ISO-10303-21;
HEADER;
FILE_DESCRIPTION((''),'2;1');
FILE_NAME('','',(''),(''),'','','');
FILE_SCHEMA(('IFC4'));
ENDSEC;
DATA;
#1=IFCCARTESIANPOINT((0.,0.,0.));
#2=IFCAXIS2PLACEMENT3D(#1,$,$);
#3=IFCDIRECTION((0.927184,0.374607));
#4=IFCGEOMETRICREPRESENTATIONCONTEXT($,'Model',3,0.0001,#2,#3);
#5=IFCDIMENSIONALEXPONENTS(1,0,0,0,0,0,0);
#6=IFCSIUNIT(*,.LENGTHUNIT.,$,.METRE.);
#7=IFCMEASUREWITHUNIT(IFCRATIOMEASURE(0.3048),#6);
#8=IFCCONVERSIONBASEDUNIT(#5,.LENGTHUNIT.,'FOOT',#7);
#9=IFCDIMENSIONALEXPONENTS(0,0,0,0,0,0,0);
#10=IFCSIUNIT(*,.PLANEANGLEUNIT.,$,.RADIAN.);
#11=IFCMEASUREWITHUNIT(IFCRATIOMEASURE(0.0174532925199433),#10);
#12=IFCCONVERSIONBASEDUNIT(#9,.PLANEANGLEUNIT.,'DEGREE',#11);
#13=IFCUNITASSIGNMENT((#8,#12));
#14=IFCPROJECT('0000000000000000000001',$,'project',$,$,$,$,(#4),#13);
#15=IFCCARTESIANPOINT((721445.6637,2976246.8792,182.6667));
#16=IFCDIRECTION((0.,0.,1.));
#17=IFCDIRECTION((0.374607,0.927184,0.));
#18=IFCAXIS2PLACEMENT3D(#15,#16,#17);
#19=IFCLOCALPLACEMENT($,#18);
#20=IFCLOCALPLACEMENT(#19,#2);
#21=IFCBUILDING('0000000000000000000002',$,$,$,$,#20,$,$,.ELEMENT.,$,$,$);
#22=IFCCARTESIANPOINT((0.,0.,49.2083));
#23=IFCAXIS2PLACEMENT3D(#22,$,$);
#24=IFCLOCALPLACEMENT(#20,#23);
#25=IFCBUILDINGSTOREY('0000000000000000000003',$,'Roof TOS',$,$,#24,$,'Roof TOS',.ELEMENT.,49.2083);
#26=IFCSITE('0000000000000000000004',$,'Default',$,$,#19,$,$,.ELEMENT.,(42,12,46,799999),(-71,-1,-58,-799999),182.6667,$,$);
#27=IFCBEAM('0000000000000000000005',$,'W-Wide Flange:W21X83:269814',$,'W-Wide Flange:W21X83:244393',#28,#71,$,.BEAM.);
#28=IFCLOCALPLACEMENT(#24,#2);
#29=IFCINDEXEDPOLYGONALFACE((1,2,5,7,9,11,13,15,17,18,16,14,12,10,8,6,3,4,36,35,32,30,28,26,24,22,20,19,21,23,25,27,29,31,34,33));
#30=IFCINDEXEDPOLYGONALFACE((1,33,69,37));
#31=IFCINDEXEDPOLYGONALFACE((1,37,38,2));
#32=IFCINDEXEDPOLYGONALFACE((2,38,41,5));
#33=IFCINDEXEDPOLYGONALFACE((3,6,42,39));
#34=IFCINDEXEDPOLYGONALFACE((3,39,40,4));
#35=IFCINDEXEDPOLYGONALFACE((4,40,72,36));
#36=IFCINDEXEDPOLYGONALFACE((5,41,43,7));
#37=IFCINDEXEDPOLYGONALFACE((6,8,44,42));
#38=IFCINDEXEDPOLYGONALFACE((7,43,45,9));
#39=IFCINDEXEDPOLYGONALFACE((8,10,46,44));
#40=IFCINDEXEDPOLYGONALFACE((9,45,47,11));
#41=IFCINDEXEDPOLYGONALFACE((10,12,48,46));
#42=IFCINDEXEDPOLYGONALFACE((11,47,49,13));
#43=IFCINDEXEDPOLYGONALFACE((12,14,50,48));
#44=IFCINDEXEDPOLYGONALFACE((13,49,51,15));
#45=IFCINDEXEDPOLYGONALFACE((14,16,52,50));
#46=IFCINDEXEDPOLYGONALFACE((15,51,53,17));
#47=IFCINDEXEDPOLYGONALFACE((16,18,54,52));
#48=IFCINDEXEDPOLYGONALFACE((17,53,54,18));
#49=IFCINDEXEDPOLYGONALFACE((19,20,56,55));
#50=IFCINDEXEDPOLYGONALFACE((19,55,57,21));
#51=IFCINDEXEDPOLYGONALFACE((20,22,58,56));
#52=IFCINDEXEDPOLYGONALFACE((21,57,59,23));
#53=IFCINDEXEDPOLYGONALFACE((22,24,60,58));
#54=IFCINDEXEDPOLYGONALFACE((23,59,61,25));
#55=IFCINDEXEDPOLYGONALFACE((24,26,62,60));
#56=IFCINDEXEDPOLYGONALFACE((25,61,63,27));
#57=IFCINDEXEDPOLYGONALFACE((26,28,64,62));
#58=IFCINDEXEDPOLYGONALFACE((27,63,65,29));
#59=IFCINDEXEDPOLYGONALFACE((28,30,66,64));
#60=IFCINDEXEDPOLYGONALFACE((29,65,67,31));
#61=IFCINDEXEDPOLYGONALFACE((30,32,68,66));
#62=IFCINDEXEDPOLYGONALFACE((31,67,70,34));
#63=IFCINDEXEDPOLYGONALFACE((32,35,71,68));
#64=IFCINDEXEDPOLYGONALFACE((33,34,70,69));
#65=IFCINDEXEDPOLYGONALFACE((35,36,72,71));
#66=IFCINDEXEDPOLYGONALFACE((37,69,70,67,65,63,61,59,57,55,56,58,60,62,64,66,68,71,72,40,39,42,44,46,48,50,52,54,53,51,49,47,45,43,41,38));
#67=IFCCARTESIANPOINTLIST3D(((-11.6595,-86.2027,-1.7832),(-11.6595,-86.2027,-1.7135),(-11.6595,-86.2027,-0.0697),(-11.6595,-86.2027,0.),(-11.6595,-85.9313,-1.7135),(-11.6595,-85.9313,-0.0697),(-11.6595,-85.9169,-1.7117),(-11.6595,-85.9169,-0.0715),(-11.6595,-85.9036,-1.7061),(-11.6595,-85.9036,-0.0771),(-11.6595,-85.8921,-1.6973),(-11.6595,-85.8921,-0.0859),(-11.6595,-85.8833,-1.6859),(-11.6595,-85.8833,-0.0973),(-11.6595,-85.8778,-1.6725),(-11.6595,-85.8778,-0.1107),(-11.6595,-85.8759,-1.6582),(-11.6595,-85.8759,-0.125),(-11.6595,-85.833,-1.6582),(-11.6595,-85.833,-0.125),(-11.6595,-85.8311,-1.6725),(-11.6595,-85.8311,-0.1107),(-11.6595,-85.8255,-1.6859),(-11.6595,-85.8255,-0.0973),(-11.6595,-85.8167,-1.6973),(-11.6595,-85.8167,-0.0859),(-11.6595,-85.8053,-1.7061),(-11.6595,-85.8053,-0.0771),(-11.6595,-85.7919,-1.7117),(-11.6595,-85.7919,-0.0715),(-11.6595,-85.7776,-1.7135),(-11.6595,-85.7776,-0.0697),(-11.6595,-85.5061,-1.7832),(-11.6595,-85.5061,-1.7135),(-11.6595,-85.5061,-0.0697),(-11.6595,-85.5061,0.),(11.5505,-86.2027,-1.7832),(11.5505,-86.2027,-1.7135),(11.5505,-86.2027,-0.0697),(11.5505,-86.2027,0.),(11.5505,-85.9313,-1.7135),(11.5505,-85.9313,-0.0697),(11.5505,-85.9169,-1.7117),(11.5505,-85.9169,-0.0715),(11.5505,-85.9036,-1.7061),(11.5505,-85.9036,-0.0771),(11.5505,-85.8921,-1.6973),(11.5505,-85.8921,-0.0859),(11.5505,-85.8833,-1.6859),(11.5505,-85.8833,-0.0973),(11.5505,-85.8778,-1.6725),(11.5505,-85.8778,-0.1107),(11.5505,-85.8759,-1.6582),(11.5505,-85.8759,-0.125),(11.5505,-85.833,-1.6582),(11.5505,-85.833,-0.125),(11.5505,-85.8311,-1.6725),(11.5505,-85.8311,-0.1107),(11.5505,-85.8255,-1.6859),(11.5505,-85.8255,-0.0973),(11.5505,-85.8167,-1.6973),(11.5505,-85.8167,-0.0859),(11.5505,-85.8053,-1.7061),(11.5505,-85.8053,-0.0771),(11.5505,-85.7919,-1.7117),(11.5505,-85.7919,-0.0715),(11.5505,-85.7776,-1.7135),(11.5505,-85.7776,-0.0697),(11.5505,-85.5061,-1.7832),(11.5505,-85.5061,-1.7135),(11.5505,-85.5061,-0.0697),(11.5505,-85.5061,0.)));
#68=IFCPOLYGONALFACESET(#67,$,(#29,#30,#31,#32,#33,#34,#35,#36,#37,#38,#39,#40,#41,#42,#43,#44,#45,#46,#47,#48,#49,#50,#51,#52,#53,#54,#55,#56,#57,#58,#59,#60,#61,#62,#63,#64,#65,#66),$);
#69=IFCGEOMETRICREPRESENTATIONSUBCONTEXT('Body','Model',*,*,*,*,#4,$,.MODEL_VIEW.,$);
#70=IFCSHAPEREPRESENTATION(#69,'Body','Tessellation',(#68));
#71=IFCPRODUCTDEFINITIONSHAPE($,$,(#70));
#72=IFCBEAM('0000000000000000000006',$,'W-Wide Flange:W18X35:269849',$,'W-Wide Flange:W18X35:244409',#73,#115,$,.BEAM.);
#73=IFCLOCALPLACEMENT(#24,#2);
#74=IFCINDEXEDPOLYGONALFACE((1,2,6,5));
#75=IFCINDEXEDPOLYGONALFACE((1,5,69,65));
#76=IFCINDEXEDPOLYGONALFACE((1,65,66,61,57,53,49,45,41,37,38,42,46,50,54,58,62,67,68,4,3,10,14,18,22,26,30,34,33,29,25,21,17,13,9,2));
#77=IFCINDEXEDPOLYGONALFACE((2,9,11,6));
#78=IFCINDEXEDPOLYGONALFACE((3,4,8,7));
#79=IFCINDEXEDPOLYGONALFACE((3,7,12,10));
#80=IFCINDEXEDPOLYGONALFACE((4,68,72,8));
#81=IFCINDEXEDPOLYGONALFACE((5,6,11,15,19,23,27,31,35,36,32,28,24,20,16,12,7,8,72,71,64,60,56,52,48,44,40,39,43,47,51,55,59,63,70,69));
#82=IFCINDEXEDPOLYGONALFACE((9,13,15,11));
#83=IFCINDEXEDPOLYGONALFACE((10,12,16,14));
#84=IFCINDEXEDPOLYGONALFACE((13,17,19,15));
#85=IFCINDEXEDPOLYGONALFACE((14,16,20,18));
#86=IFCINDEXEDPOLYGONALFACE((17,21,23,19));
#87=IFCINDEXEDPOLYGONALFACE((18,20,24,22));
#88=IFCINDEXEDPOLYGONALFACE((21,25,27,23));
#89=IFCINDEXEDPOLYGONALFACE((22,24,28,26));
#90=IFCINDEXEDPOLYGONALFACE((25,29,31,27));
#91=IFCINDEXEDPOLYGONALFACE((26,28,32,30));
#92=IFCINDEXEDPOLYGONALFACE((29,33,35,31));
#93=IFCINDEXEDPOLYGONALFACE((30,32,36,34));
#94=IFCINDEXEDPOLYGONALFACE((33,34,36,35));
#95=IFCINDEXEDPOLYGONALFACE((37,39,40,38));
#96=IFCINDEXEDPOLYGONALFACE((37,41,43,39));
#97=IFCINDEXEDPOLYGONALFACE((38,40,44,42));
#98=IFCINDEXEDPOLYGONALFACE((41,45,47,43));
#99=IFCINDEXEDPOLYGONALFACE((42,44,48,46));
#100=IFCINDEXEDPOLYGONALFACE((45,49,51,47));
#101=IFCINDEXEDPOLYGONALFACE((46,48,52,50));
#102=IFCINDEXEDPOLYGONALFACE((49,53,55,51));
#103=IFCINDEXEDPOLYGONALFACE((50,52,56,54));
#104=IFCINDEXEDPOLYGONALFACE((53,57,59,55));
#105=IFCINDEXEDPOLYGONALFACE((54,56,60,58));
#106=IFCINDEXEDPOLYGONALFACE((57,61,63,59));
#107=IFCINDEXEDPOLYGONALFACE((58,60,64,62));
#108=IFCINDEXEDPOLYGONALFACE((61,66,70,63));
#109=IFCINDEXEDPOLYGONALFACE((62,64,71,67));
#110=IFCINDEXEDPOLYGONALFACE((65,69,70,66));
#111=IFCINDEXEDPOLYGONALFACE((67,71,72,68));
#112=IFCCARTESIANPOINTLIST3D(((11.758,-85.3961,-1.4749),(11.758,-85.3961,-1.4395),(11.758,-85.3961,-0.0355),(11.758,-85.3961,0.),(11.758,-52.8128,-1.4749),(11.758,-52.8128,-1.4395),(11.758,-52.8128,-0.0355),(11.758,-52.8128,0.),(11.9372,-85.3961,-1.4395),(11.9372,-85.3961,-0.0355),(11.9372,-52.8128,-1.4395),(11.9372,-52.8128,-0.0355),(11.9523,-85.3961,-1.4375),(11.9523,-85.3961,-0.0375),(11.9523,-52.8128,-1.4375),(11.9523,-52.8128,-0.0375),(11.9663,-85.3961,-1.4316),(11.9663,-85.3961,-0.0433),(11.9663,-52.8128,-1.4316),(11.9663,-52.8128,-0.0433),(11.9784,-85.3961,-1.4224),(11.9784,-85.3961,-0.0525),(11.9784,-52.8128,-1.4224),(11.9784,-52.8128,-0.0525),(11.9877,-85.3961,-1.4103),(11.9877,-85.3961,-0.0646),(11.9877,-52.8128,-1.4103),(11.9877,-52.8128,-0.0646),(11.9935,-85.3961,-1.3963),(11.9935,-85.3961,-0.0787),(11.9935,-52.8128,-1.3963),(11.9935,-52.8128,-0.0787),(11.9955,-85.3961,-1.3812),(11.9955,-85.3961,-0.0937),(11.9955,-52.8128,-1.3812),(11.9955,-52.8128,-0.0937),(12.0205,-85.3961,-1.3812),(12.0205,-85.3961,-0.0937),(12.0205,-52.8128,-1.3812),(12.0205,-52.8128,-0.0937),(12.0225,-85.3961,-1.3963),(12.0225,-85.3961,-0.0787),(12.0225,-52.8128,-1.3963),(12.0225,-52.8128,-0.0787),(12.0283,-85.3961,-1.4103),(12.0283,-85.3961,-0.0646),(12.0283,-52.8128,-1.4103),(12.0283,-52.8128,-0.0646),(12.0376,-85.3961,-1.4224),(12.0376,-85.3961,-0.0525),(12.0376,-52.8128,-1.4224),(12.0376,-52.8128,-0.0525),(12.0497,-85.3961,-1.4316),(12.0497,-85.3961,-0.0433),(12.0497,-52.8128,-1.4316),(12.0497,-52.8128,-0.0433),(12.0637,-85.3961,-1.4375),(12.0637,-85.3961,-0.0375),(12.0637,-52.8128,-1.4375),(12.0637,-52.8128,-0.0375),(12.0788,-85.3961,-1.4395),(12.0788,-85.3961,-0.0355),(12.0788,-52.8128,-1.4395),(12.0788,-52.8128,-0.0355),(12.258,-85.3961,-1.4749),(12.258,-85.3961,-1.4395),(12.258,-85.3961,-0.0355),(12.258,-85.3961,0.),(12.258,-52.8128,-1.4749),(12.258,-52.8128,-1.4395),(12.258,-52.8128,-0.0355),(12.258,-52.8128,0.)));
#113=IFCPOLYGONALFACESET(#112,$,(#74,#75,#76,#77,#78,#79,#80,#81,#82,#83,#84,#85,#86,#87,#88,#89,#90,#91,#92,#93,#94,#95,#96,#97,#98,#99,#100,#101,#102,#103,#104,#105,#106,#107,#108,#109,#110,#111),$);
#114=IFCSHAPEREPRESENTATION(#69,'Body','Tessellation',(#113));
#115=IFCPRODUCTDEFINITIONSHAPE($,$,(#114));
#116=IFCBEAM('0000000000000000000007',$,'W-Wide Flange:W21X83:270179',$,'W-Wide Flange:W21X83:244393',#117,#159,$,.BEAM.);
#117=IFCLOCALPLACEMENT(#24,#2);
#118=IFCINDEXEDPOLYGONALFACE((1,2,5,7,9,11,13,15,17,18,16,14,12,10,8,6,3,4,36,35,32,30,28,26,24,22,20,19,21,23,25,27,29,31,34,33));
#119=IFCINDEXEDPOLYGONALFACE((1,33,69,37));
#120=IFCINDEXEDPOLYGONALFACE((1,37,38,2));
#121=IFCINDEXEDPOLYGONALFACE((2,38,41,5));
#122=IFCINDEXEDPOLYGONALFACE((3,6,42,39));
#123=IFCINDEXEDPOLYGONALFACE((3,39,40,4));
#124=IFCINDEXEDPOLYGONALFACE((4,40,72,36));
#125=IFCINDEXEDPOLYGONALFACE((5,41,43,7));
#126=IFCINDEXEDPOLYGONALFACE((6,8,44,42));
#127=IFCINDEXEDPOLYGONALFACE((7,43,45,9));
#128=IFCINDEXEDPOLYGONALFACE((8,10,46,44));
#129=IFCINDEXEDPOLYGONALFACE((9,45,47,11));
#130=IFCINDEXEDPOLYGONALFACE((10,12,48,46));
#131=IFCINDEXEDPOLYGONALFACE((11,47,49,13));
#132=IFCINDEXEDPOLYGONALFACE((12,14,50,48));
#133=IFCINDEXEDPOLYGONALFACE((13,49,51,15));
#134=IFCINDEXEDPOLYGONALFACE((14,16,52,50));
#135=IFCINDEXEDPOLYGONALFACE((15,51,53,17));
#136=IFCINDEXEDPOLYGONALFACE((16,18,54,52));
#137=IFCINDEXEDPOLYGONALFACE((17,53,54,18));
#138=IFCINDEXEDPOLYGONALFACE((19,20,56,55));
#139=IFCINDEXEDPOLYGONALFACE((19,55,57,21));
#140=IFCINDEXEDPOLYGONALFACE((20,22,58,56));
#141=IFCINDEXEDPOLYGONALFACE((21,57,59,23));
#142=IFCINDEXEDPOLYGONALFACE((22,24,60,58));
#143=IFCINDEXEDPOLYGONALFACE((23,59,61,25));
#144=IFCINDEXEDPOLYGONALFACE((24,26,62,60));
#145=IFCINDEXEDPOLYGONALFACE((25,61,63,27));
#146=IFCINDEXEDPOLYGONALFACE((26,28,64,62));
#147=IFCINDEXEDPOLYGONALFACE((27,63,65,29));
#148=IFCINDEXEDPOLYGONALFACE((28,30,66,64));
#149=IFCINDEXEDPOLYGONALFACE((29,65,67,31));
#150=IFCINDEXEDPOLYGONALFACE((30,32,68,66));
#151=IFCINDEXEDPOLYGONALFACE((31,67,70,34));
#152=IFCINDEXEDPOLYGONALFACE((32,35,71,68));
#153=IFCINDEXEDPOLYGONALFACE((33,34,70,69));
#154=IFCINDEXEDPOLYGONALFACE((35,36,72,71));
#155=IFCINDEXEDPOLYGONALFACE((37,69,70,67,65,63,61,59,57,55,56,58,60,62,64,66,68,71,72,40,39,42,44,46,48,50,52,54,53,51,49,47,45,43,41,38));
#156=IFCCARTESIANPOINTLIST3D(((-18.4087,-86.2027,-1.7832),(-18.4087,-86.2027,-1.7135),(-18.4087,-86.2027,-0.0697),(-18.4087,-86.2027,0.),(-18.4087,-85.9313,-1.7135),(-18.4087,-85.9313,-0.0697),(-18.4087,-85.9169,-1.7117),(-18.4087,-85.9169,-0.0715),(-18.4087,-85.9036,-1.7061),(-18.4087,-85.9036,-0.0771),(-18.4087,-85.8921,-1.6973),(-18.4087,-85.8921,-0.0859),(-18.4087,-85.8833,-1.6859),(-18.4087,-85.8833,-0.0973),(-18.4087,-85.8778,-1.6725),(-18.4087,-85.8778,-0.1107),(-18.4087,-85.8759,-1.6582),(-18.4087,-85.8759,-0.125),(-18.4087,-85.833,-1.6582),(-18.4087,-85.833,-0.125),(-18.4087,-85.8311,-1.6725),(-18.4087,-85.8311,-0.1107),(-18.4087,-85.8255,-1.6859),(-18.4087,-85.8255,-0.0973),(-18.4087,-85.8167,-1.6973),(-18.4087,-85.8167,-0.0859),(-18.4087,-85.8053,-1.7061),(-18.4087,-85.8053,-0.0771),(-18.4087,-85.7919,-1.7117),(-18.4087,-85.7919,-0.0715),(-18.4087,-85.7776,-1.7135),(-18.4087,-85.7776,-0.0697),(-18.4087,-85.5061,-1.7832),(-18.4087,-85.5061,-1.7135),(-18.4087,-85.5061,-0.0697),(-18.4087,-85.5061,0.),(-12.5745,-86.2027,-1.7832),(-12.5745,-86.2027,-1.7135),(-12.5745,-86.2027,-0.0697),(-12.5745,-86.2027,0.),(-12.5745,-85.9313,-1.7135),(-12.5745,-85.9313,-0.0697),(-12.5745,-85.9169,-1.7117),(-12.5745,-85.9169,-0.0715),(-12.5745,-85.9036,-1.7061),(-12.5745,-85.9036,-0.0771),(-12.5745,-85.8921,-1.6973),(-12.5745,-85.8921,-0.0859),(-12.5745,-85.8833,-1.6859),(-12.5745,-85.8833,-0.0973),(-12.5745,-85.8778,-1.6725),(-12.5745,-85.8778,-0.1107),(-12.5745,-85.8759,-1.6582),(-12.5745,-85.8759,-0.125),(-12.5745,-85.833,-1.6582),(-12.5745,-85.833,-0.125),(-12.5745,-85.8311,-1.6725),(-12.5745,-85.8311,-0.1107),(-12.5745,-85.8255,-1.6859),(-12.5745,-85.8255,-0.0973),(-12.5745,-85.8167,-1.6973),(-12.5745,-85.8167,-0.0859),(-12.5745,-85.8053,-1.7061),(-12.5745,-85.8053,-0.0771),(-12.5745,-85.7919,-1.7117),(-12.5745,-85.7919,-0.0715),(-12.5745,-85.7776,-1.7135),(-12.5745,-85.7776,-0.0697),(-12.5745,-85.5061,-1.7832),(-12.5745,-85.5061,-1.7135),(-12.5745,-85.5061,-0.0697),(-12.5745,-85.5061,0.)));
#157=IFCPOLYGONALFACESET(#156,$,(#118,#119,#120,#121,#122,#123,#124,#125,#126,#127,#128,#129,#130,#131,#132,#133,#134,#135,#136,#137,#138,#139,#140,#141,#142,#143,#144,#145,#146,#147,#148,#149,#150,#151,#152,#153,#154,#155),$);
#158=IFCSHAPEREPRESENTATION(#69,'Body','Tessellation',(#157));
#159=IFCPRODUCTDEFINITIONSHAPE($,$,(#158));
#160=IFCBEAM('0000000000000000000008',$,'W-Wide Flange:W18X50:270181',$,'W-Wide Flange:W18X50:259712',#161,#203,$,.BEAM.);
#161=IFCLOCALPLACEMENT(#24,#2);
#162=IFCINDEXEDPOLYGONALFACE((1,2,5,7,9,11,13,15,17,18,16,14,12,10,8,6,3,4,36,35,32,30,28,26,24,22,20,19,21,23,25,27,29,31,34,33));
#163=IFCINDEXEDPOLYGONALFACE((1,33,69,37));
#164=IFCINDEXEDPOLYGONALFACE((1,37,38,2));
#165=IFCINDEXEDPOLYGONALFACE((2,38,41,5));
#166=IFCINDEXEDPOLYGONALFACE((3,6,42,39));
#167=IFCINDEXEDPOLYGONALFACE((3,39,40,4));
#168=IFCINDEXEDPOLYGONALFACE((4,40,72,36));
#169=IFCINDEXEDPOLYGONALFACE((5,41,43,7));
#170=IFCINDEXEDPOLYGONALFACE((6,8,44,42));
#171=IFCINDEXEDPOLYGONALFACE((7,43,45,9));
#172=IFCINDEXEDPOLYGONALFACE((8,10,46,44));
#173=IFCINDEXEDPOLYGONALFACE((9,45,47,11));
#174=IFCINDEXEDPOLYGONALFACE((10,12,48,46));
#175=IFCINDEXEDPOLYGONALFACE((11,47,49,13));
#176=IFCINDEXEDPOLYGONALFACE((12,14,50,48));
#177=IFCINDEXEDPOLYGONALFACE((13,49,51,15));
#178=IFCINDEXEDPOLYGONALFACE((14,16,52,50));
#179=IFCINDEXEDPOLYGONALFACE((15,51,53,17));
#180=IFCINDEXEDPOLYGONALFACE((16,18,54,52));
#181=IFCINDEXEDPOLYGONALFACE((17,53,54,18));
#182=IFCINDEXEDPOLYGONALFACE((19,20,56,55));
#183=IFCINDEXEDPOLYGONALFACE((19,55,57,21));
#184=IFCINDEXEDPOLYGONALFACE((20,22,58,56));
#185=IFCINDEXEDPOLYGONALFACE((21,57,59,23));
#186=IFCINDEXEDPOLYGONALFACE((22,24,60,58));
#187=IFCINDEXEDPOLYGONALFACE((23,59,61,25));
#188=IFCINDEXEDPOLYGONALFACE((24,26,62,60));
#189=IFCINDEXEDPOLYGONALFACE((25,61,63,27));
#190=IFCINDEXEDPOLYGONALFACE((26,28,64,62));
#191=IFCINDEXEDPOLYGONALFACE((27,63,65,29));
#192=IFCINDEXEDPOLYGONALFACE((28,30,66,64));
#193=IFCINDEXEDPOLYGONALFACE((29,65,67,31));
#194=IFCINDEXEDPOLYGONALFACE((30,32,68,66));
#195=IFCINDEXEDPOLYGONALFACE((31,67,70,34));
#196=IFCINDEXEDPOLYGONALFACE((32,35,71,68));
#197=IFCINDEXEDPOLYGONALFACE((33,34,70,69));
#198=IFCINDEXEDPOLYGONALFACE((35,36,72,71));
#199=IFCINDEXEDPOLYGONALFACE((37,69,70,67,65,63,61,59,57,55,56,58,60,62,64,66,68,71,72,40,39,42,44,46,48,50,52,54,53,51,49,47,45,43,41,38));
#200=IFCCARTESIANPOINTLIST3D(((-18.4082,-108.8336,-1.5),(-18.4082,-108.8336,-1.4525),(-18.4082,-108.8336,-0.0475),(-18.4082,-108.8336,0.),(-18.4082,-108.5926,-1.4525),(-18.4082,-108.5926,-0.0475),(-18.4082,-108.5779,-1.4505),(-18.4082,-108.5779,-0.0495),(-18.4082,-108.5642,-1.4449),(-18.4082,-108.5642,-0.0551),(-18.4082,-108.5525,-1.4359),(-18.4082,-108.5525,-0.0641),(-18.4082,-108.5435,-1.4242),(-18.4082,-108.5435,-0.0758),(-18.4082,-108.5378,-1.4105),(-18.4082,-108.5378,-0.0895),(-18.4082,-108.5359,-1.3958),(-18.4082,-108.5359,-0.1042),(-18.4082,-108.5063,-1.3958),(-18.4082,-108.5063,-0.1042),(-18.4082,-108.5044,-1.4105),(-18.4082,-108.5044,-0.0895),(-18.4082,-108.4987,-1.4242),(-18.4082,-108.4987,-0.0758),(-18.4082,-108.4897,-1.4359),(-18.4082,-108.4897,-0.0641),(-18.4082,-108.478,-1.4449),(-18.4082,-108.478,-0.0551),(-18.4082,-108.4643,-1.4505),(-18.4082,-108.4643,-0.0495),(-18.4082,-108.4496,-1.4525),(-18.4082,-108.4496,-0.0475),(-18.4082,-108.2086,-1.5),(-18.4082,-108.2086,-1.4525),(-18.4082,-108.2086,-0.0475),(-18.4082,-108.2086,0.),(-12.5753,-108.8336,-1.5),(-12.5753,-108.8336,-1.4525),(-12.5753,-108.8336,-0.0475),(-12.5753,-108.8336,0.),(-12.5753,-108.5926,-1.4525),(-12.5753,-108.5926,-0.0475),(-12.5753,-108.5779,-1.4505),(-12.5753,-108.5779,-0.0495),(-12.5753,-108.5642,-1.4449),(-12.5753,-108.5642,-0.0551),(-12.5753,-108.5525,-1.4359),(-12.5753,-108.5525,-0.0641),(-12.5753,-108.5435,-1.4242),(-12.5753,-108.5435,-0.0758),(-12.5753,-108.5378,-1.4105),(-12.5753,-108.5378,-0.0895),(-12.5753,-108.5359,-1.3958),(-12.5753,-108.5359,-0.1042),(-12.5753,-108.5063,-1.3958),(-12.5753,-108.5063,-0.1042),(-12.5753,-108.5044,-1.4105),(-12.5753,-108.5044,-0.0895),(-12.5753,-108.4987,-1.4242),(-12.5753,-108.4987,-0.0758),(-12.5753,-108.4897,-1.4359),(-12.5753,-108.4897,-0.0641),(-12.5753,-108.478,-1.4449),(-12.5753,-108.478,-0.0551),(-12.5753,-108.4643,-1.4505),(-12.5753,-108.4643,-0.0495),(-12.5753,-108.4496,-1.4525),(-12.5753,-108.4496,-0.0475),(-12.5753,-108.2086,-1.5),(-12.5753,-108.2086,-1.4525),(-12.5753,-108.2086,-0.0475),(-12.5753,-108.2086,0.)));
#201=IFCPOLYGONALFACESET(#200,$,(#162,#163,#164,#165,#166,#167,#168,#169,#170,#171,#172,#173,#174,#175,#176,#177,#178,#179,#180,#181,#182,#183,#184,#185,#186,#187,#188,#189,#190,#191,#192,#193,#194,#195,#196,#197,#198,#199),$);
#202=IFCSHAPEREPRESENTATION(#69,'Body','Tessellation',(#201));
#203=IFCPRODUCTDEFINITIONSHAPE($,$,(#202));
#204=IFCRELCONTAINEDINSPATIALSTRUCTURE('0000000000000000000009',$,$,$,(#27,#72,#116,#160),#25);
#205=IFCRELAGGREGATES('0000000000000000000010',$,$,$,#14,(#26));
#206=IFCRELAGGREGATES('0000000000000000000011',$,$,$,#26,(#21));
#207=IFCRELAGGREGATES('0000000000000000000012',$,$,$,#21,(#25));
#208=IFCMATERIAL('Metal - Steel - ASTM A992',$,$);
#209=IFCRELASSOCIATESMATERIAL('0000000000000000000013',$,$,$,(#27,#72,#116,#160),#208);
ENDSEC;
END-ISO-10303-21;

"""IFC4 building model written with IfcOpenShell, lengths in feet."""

from ifc_helpers import new_model, entity, si_unit, converted_unit, direction, frame, frame_2d, origin, place, context, subcontext, project, spatial, i_section, extrude, material, element, save


model = new_model("IFC4")

# Units and contexts
model_context = context("Model", 3, precision=0.0001, world=origin(), true_north=direction((0.927184, 0.374607)))
body_context = subcontext(model_context, "Body", "Model", "MODEL_VIEW")
ifc_project = project(units=[converted_unit("LENGTHUNIT", "FOOT", entity("IfcRatioMeasure", 0.3048), si_unit("LENGTHUNIT", "METRE"), dimensions=[1, 0, 0, 0, 0, 0, 0]), converted_unit("PLANEANGLEUNIT", "DEGREE", entity("IfcRatioMeasure", 0.0174532925199433), si_unit("PLANEANGLEUNIT", "RADIAN"), dimensions=[0, 0, 0, 0, 0, 0, 0])], contexts=[model_context])

# Site, building, storey
site_placement = place(None, frame((721445.6637, 2976246.8792, 182.6667), z_axis=(0.0, 0.0, 1.0), x_axis=(0.374607, 0.927184, 0.0)))
site = spatial("IfcSite", under=ifc_project, at=site_placement, Name="Default", CompositionType="ELEMENT", RefLatitude=(42, 12, 46, 799999), RefLongitude=(-71, -1, -58, -799999), RefElevation=182.6667)
building_placement = place(site_placement, origin())
building = spatial("IfcBuilding", under=site, at=building_placement, CompositionType="ELEMENT")
storey_placement = place(building_placement, frame((0.0, 0.0, 49.2083)))
storey = spatial("IfcBuildingStorey", under=building, at=storey_placement, Name="Roof TOS", LongName="Roof TOS", CompositionType="ELEMENT", Elevation=49.2083)

# Beams
ifc_material = material(Name="Metal - Steel - ASTM A992")
beam_1_placement = place(storey_placement, frame((12.008, -85.8544, 0.0), z_axis=(0.0, 0.0, 1.0), x_axis=(-1.0, 0.0, 0.0)))
element("IfcBeam", 1, at=beam_1_placement, inside=storey, material=ifc_material, Name="W-Wide Flange:W21X83:269814", ObjectType="W-Wide Flange:W21X83:244393", PredefinedType="BEAM", context=body_context, shape_type="SweptSolid", body=[
    extrude(i_section(OverallWidth=0.6966, OverallDepth=1.7832, WebThickness=0.043, FlangeThickness=0.0697, FilletRadius=0.0553, at=frame_2d((0.0, 0.0), x_axis=(0.0, 1.0))), frame((0.4575, 0.0, -0.8916), z_axis=(1.0, 0.0, 0.0), x_axis=(0.0, 0.0, -1.0)), (0.0, 0.0, 1.0), 23.21),
])
beam_2_placement = place(storey_placement, frame((12.008, -85.8544, 0.0), z_axis=(0.0, 0.0, 1.0), x_axis=(0.0, 1.0, 0.0)))
element("IfcBeam", 2, at=beam_2_placement, inside=storey, material=ifc_material, Name="W-Wide Flange:W18X35:269849", ObjectType="W-Wide Flange:W18X35:244409", PredefinedType="BEAM", context=body_context, shape_type="SweptSolid", body=[
    extrude(i_section(OverallWidth=0.5, OverallDepth=1.4749, WebThickness=0.0251, FlangeThickness=0.0355, FilletRadius=0.0583, at=frame_2d((0.0, 0.0), x_axis=(0.0, 1.0))), frame((0.4583, 0.0, -0.7375), z_axis=(1.0, 0.0, 0.0), x_axis=(0.0, 0.0, -1.0)), (0.0, 0.0, 1.0), 32.5833),
])
beam_3_placement = place(storey_placement, frame((-12.117, -85.8544, 0.0), z_axis=(0.0, 0.0, 1.0), x_axis=(-1.0, 0.0, 0.0)))
element("IfcBeam", 3, at=beam_3_placement, inside=storey, material=ifc_material, Name="W-Wide Flange:W21X83:270179", ObjectType="W-Wide Flange:W21X83:244393", PredefinedType="BEAM", context=body_context, shape_type="SweptSolid", body=[
    extrude(i_section(OverallWidth=0.6966, OverallDepth=1.7832, WebThickness=0.043, FlangeThickness=0.0697, FilletRadius=0.0553, at=frame_2d((0.0, 0.0), x_axis=(0.0, 1.0))), frame((0.4575, 0.0, -0.8916), z_axis=(1.0, 0.0, 0.0), x_axis=(0.0, 0.0, -1.0)), (0.0, 0.0, 1.0), 5.8341),
])
beam_4_placement = place(storey_placement, frame((-12.117, -108.5211, 0.0), z_axis=(0.0, 0.0, 1.0), x_axis=(-1.0, 0.0, 0.0)))
element("IfcBeam", 4, at=beam_4_placement, inside=storey, material=ifc_material, Name="W-Wide Flange:W18X50:270181", ObjectType="W-Wide Flange:W18X50:259712", PredefinedType="BEAM", context=body_context, shape_type="SweptSolid", body=[
    extrude(i_section(OverallWidth=0.625, OverallDepth=1.5, WebThickness=0.0296, FlangeThickness=0.0475, FilletRadius=0.0566, at=frame_2d((0.0, 0.0), x_axis=(0.0, 1.0))), frame((0.4583, 0.0, -0.75), z_axis=(1.0, 0.0, 0.0), x_axis=(0.0, 0.0, -1.0)), (0.0, 0.0, 1.0), 5.8328),
])

save(model, "model.ifc")
